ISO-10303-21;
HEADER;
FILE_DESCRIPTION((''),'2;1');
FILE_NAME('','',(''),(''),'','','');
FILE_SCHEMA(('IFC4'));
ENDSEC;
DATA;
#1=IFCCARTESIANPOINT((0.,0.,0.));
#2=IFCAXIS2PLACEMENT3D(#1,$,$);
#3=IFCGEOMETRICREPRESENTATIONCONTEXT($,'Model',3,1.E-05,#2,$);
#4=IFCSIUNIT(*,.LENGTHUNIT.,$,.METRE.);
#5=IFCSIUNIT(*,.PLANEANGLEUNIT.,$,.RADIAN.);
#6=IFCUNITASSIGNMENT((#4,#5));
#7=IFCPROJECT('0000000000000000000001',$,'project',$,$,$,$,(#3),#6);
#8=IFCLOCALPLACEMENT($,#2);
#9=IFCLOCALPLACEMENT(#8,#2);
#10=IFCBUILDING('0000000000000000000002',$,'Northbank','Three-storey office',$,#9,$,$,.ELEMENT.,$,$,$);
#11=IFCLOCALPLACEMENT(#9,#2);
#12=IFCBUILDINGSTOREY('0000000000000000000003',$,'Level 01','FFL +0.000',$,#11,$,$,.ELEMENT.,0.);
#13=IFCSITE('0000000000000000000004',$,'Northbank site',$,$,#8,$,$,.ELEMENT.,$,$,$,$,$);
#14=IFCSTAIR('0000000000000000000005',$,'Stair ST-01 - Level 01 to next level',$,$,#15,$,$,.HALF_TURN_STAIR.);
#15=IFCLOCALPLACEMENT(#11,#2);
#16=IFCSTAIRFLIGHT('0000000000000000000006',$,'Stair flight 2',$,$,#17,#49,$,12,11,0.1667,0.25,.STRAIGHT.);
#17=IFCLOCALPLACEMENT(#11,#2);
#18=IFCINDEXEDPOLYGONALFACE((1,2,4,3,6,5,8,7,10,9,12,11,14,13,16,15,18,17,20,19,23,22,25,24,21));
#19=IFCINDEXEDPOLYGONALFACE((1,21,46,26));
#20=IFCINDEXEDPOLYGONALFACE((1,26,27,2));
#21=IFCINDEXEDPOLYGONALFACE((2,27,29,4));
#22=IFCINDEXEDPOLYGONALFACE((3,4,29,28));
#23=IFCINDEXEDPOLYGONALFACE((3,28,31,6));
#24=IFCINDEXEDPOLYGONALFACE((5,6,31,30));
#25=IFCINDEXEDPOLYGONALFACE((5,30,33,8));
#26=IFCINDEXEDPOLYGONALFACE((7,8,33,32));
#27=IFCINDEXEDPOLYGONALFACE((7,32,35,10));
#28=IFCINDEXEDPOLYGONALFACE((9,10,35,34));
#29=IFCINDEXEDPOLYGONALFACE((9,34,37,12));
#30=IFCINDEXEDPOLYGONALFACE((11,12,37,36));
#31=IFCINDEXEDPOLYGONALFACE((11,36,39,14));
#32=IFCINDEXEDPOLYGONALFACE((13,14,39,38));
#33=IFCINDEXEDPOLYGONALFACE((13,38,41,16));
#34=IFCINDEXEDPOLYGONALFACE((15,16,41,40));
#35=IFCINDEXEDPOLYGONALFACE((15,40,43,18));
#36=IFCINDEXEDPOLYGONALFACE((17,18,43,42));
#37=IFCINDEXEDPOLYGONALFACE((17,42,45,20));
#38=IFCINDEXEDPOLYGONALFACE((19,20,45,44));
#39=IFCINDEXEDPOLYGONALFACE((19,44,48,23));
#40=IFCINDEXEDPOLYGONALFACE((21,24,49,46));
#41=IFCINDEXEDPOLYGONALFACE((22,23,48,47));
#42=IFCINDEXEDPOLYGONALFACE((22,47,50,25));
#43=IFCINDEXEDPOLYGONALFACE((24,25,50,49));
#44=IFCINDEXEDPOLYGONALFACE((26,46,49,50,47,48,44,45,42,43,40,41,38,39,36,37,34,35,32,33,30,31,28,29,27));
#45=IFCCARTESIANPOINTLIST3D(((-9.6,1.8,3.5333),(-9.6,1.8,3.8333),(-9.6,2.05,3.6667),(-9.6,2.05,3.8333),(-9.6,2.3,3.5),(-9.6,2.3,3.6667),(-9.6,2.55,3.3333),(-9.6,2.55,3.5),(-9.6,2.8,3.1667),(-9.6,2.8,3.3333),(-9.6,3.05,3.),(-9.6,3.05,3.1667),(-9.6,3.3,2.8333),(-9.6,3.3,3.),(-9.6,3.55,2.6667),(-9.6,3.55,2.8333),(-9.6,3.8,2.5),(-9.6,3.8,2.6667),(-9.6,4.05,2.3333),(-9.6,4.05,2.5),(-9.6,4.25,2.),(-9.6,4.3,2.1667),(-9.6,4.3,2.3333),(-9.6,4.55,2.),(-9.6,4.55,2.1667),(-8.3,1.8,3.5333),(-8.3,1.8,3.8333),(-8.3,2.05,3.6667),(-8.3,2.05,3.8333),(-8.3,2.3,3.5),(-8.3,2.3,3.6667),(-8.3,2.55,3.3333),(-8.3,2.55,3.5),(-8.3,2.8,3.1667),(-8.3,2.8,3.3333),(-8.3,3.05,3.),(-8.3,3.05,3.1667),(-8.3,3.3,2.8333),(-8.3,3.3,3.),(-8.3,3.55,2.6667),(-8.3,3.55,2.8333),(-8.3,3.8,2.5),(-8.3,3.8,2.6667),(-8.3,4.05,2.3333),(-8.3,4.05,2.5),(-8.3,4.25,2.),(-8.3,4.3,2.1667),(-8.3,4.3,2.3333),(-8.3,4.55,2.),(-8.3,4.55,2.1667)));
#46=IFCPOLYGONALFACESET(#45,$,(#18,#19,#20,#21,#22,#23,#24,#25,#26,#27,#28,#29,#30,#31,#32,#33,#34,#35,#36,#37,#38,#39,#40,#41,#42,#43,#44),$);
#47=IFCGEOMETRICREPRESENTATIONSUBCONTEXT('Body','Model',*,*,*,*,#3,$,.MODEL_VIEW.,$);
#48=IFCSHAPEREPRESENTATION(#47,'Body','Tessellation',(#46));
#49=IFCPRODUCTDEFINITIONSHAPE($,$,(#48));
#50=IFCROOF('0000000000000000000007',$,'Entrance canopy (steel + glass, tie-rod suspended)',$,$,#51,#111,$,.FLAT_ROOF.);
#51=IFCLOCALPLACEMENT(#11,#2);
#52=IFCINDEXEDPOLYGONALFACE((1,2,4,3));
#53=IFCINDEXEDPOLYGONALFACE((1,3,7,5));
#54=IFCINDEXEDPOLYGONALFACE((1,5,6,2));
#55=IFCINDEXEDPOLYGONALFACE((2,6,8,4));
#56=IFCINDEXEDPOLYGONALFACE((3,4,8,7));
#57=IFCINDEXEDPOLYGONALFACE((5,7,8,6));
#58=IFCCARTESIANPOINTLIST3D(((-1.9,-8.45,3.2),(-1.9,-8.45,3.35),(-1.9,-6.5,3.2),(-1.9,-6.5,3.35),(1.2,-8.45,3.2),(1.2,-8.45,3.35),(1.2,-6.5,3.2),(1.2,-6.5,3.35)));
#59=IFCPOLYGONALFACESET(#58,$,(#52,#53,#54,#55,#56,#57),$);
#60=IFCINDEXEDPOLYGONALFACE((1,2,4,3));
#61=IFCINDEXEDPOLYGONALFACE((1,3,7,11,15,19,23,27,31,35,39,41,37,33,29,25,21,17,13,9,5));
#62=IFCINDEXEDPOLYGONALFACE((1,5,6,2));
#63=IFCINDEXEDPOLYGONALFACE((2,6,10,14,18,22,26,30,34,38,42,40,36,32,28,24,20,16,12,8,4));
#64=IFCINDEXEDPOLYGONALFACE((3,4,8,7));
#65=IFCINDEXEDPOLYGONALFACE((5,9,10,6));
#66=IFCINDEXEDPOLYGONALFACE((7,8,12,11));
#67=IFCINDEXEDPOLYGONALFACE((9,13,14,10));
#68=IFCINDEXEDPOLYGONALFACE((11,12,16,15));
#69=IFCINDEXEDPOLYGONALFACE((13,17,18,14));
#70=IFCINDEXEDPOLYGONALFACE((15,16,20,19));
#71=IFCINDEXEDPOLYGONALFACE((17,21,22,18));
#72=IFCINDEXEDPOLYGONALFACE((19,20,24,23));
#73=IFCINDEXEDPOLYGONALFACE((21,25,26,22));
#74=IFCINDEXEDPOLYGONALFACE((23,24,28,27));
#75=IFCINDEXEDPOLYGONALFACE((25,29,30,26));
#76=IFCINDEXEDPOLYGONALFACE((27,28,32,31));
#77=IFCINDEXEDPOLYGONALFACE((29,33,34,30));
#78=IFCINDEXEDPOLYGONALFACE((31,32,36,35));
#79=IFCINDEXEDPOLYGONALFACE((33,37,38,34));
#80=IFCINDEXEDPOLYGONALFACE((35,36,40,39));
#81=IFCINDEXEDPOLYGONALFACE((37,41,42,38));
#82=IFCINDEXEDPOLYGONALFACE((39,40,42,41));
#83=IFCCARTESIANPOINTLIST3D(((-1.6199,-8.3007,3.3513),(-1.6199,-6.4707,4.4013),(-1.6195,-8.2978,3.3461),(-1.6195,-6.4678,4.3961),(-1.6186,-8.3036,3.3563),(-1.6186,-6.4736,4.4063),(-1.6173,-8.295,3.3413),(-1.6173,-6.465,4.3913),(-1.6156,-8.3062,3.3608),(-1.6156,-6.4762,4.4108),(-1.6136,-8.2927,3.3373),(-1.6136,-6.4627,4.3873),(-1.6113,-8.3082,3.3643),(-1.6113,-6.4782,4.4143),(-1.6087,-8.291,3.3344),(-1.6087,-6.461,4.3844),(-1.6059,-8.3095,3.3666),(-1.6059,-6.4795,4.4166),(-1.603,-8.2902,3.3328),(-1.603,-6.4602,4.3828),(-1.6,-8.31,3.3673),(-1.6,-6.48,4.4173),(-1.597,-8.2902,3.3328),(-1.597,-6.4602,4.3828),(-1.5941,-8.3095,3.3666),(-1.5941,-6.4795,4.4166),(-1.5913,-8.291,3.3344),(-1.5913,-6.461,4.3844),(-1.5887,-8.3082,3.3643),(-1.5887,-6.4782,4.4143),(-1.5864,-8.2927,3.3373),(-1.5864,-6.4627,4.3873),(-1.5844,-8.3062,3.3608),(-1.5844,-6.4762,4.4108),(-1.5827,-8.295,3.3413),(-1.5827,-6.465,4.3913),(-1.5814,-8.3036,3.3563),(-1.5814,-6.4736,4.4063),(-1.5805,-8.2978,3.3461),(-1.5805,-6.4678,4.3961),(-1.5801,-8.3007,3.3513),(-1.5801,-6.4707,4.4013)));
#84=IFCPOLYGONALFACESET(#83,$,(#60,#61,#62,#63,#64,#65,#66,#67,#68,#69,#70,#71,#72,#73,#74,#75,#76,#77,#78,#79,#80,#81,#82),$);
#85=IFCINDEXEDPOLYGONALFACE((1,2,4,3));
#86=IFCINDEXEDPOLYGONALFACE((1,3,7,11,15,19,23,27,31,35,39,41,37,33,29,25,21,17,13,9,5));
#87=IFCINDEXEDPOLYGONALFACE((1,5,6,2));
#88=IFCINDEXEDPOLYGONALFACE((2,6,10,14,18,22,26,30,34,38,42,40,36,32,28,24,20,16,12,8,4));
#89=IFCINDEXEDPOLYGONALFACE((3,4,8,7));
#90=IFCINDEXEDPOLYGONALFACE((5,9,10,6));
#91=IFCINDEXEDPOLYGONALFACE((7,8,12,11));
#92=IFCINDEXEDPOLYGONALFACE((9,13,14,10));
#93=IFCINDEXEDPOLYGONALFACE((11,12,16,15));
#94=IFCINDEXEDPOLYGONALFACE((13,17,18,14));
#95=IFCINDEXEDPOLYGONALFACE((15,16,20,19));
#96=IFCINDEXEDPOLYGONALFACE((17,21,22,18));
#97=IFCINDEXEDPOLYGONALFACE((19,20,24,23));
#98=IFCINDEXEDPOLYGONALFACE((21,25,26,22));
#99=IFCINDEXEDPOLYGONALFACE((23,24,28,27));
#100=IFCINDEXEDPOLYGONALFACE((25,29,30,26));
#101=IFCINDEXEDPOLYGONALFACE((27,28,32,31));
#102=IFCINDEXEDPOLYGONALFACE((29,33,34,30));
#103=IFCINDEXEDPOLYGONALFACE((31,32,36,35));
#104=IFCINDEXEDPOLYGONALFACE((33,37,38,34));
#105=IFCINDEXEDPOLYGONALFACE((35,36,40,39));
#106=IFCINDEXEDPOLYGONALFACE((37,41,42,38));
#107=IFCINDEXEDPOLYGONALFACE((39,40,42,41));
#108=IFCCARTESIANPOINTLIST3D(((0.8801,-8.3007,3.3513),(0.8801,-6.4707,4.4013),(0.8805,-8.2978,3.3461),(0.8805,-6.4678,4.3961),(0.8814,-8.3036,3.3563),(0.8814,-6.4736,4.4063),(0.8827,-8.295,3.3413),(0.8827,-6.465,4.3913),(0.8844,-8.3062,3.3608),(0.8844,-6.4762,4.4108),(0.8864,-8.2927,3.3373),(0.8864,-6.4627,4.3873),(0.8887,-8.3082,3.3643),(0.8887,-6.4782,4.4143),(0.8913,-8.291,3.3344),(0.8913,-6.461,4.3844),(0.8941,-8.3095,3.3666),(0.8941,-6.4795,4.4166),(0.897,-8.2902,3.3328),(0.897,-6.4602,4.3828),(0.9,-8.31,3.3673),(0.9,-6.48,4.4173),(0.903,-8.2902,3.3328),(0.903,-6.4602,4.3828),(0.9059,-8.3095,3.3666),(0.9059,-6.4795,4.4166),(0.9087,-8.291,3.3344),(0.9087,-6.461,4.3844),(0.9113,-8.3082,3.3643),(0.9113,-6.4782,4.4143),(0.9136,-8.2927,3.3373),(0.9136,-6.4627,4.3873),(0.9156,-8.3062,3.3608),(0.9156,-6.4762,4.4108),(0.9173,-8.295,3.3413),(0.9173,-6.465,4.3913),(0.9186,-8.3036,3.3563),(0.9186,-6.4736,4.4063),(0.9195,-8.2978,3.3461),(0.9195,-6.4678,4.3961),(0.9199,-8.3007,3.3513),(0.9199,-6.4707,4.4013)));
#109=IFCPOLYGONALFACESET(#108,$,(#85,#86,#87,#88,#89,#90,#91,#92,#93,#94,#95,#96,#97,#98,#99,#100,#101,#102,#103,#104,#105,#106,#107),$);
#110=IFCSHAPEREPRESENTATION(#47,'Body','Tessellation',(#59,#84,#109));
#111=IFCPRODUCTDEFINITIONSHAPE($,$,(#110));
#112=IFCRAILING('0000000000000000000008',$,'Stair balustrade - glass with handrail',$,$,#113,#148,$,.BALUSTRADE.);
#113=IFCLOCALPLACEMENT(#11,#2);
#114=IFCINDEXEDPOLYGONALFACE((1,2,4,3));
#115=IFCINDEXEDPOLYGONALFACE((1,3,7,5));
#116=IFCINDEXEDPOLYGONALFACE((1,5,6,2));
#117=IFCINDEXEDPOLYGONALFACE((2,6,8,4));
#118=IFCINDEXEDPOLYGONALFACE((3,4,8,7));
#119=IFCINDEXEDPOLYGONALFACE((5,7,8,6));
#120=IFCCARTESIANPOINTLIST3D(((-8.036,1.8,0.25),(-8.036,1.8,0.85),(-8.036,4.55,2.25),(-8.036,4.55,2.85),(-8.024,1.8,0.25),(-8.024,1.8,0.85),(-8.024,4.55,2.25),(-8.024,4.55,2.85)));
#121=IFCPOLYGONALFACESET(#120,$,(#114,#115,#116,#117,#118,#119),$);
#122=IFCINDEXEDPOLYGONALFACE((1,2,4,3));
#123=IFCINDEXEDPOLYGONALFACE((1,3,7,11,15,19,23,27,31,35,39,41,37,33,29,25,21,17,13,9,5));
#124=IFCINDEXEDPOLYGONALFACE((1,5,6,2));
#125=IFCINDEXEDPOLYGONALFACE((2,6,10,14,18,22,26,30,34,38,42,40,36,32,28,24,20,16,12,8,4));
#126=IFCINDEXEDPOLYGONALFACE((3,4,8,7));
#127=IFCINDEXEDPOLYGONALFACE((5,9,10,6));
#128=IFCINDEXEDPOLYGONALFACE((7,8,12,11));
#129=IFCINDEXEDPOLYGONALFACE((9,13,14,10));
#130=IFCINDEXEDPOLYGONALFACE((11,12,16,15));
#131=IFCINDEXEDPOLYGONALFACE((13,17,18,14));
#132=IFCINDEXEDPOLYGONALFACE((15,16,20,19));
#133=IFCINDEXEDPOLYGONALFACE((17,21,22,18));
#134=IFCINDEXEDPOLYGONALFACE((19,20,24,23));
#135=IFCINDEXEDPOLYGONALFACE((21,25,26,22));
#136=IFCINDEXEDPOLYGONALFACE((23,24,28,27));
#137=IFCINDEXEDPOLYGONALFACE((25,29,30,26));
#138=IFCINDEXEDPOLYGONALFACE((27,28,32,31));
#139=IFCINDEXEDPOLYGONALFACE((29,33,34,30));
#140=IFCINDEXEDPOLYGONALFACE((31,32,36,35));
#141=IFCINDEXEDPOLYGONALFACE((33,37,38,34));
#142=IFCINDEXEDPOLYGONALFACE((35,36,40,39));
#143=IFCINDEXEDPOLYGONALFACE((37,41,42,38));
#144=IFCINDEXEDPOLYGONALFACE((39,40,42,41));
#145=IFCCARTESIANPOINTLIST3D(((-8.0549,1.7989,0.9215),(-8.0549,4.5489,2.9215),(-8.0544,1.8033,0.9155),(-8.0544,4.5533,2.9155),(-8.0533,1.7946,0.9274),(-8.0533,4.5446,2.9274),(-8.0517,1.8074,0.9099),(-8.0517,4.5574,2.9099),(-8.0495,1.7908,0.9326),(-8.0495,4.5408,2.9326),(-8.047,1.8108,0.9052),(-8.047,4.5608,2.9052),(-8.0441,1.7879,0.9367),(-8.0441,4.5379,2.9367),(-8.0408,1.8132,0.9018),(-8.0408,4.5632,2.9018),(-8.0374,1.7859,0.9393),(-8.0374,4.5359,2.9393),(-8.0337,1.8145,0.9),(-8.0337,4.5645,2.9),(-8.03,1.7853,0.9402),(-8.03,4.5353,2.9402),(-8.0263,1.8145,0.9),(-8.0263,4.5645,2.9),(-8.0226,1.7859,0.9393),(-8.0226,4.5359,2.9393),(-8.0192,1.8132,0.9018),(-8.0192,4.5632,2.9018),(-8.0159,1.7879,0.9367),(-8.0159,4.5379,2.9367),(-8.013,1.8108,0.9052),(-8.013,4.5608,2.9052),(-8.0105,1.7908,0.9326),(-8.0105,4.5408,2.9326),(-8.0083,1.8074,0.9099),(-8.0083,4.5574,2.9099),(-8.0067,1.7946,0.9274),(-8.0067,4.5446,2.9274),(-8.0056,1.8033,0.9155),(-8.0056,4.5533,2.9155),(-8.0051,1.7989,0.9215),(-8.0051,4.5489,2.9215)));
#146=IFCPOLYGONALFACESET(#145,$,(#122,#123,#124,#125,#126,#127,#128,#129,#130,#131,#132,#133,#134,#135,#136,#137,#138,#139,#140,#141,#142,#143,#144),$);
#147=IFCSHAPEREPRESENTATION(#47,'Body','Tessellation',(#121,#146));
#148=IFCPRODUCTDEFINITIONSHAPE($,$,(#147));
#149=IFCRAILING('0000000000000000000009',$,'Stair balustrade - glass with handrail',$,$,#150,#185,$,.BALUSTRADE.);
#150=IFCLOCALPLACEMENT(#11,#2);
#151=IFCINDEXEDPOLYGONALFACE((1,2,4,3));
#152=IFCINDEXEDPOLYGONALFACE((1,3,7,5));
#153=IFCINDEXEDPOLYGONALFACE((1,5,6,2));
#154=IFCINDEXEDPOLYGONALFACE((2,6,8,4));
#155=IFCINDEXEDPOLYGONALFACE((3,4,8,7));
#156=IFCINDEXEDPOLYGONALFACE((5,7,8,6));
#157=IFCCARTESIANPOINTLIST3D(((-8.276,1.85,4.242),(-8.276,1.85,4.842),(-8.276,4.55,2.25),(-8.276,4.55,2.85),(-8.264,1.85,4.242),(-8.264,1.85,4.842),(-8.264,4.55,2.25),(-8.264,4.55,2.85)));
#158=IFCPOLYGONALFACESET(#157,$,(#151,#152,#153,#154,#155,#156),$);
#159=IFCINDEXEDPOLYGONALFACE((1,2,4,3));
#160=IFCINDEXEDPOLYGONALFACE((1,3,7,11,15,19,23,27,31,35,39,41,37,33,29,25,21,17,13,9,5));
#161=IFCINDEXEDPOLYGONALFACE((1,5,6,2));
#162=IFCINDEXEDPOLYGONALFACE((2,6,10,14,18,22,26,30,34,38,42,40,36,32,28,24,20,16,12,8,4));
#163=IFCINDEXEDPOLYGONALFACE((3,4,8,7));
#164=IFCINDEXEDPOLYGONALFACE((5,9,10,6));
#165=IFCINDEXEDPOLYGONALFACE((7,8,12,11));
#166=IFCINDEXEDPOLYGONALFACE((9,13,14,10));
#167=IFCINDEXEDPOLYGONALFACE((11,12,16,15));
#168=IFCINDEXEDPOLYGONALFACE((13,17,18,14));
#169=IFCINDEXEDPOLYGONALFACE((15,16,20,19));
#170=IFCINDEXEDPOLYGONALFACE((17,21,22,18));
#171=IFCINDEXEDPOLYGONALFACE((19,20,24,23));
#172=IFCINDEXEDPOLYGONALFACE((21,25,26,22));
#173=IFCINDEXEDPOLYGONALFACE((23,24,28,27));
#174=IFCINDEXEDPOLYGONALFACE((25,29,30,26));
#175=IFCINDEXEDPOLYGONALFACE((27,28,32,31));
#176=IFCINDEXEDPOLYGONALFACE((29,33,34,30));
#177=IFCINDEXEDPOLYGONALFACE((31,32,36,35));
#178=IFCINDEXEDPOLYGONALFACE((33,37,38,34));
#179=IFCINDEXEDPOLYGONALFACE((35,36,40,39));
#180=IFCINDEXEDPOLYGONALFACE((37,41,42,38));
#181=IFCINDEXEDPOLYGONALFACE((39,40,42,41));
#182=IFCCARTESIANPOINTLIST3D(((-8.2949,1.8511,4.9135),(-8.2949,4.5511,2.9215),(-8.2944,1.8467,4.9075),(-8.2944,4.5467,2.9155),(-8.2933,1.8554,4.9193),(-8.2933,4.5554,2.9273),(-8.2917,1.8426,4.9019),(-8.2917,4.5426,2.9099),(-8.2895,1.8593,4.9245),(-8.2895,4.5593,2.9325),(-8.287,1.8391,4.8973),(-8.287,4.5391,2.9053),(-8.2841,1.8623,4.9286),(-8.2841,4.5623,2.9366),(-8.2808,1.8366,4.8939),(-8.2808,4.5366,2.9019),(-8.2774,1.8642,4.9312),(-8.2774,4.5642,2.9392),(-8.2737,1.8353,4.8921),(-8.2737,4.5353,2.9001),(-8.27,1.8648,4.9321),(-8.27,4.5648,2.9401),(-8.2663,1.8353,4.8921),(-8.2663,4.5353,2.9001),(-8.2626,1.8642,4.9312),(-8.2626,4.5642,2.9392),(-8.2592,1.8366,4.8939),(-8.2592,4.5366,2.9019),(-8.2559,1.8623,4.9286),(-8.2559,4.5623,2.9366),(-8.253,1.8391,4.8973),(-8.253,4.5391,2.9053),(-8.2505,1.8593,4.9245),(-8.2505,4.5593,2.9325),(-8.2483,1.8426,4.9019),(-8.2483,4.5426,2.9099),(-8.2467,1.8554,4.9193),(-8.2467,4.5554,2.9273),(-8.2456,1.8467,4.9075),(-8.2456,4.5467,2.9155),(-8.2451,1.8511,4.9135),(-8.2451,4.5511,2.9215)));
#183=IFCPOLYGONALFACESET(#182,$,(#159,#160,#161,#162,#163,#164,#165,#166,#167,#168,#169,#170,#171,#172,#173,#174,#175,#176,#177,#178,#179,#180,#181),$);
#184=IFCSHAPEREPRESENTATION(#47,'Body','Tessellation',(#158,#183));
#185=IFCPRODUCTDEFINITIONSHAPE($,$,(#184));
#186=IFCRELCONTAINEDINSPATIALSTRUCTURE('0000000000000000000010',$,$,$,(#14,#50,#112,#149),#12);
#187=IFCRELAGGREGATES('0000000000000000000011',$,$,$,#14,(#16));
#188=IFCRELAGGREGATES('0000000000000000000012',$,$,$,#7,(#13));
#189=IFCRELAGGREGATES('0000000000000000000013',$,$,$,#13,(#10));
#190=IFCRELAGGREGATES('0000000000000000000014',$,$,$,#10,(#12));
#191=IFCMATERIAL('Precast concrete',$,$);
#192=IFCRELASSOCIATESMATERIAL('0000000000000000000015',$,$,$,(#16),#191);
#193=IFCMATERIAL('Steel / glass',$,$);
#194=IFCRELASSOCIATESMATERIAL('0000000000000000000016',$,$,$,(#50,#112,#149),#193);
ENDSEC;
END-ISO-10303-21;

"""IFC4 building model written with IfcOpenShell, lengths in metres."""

from ifc_helpers import new_model, si_unit, frame, origin, place, context, subcontext, project, spatial, polyline, rectangle, circle, outline, extrude, material, element, aggregate, save


model = new_model("IFC4")

# Units and contexts
model_context = context("Model", 3, precision=1e-05, world=origin())
body_context = subcontext(model_context, "Body", "Model", "MODEL_VIEW")
ifc_project = project(units=[si_unit("LENGTHUNIT", "METRE"), si_unit("PLANEANGLEUNIT", "RADIAN")], contexts=[model_context])

# Site, building, storey
site_placement = place(None, origin())
site = spatial("IfcSite", under=ifc_project, at=site_placement, Name="Northbank site", CompositionType="ELEMENT")
building_placement = place(site_placement, origin())
building = spatial("IfcBuilding", under=site, at=building_placement, Name="Northbank", Description="Three-storey office", CompositionType="ELEMENT")
storey_placement = place(building_placement, origin())
storey = spatial("IfcBuildingStorey", under=building, at=storey_placement, Name="Level 01", Description="FFL +0.000", CompositionType="ELEMENT", Elevation=0.0)

# Stair
stair_placement = place(storey_placement, origin())
stair = element("IfcStair", 1, at=stair_placement, inside=storey, Name="Stair ST-01 - Level 01 to next level", PredefinedType="HALF_TURN_STAIR")
ifc_material_1 = material(Name="Precast concrete")

# Stair flight
stair_flight_1_placement = place(storey_placement, origin())
stair_flight_1 = element("IfcStairFlight", 2, at=stair_flight_1_placement, material=ifc_material_1, Name="Stair flight 2", NumberOfRisers=12, NumberOfTreads=11, PredefinedType="STRAIGHT", RiserHeight=0.1667, TreadLength=0.25, context=body_context, shape_type="SweptSolid", body=[
    extrude(outline(polyline([(4.55, 2.0), (4.55, 2.1667), (4.3, 2.1667), (4.3, 2.3333), (4.05, 2.3333), (4.05, 2.5), (3.8, 2.5), (3.8, 2.6667), (3.55, 2.6667), (3.55, 2.8333), (3.3, 2.8333), (3.3, 3.0), (3.05, 3.0), (3.05, 3.1667), (2.8, 3.1667), (2.8, 3.3333), (2.55, 3.3333), (2.55, 3.5), (2.3, 3.5), (2.3, 3.6667), (2.05, 3.6667), (2.05, 3.8333), (1.8, 3.8333), (1.8, 3.5333), (4.25, 2.0), (4.55, 2.0)])), frame((-9.6, 0.0, 0.0), z_axis=(1.0, 0.0, 0.0), x_axis=(0.0, 1.0, 0.0)), (0.0, 0.0, 1.0), 1.3),
])
aggregate(stair, [stair_flight_1])

# Roof
ifc_material_2 = material(Name="Steel / glass")
roof_placement = place(storey_placement, origin())
element("IfcRoof", 3, at=roof_placement, inside=storey, material=ifc_material_2, Name="Entrance canopy (steel + glass, tie-rod suspended)", PredefinedType="FLAT_ROOF", context=body_context, shape_type="SweptSolid", body=[
    extrude(rectangle(XDim=3.1, YDim=1.95), frame((-0.35, -7.475, 3.2)), (0.0, 0.0, 1.0), 0.15),
    extrude(circle(Radius=0.02), frame((-1.6, -8.3, 3.35), z_axis=(0.0, 0.867367, 0.497669), x_axis=(0.0, -0.497669, 0.867367)), (0.0, 0.0, 1.0), 2.1098),
    extrude(circle(Radius=0.02), frame((0.9, -8.3, 3.35), z_axis=(0.0, 0.867367, 0.497669), x_axis=(0.0, -0.497669, 0.867367)), (0.0, 0.0, 1.0), 2.1098),
])

# Railings
railing_1_placement = place(storey_placement, origin())
element("IfcRailing", 4, at=railing_1_placement, inside=storey, material=ifc_material_2, Name="Stair balustrade - glass with handrail", PredefinedType="BALUSTRADE", context=body_context, shape_type="SweptSolid", body=[
    extrude(outline(polyline([(1.8, 0.25), (4.55, 2.25), (4.55, 2.85), (1.8, 0.85), (1.8, 0.25)])), frame((-8.036, 0.0, 0.0), z_axis=(1.0, 0.0, 0.0), x_axis=(0.0, 1.0, 0.0)), (0.0, 0.0, 1.0), 0.012),
    extrude(circle(Radius=0.025), frame((-8.03, 1.8, 0.92), z_axis=(0.0, 0.808736, 0.588172), x_axis=(0.0, -0.588172, 0.808736)), (0.0, 0.0, 1.0), 3.4004),
])
railing_2_placement = place(storey_placement, origin())
element("IfcRailing", 5, at=railing_2_placement, inside=storey, material=ifc_material_2, Name="Stair balustrade - glass with handrail", PredefinedType="BALUSTRADE", context=body_context, shape_type="SweptSolid", body=[
    extrude(outline(polyline([(4.55, 2.25), (1.85, 4.242), (1.85, 4.842), (4.55, 2.85), (4.55, 2.25)])), frame((-8.276, 0.0, 0.0), z_axis=(1.0, 0.0, 0.0), x_axis=(0.0, 1.0, 0.0)), (0.0, 0.0, 1.0), 0.012),
    extrude(circle(Radius=0.025), frame((-8.27, 4.55, 2.92), z_axis=(0.0, -0.804696, 0.593687), x_axis=(0.0, 0.593687, 0.804696)), (0.0, 0.0, 1.0), 3.3553),
])

save(model, "model.ifc")
